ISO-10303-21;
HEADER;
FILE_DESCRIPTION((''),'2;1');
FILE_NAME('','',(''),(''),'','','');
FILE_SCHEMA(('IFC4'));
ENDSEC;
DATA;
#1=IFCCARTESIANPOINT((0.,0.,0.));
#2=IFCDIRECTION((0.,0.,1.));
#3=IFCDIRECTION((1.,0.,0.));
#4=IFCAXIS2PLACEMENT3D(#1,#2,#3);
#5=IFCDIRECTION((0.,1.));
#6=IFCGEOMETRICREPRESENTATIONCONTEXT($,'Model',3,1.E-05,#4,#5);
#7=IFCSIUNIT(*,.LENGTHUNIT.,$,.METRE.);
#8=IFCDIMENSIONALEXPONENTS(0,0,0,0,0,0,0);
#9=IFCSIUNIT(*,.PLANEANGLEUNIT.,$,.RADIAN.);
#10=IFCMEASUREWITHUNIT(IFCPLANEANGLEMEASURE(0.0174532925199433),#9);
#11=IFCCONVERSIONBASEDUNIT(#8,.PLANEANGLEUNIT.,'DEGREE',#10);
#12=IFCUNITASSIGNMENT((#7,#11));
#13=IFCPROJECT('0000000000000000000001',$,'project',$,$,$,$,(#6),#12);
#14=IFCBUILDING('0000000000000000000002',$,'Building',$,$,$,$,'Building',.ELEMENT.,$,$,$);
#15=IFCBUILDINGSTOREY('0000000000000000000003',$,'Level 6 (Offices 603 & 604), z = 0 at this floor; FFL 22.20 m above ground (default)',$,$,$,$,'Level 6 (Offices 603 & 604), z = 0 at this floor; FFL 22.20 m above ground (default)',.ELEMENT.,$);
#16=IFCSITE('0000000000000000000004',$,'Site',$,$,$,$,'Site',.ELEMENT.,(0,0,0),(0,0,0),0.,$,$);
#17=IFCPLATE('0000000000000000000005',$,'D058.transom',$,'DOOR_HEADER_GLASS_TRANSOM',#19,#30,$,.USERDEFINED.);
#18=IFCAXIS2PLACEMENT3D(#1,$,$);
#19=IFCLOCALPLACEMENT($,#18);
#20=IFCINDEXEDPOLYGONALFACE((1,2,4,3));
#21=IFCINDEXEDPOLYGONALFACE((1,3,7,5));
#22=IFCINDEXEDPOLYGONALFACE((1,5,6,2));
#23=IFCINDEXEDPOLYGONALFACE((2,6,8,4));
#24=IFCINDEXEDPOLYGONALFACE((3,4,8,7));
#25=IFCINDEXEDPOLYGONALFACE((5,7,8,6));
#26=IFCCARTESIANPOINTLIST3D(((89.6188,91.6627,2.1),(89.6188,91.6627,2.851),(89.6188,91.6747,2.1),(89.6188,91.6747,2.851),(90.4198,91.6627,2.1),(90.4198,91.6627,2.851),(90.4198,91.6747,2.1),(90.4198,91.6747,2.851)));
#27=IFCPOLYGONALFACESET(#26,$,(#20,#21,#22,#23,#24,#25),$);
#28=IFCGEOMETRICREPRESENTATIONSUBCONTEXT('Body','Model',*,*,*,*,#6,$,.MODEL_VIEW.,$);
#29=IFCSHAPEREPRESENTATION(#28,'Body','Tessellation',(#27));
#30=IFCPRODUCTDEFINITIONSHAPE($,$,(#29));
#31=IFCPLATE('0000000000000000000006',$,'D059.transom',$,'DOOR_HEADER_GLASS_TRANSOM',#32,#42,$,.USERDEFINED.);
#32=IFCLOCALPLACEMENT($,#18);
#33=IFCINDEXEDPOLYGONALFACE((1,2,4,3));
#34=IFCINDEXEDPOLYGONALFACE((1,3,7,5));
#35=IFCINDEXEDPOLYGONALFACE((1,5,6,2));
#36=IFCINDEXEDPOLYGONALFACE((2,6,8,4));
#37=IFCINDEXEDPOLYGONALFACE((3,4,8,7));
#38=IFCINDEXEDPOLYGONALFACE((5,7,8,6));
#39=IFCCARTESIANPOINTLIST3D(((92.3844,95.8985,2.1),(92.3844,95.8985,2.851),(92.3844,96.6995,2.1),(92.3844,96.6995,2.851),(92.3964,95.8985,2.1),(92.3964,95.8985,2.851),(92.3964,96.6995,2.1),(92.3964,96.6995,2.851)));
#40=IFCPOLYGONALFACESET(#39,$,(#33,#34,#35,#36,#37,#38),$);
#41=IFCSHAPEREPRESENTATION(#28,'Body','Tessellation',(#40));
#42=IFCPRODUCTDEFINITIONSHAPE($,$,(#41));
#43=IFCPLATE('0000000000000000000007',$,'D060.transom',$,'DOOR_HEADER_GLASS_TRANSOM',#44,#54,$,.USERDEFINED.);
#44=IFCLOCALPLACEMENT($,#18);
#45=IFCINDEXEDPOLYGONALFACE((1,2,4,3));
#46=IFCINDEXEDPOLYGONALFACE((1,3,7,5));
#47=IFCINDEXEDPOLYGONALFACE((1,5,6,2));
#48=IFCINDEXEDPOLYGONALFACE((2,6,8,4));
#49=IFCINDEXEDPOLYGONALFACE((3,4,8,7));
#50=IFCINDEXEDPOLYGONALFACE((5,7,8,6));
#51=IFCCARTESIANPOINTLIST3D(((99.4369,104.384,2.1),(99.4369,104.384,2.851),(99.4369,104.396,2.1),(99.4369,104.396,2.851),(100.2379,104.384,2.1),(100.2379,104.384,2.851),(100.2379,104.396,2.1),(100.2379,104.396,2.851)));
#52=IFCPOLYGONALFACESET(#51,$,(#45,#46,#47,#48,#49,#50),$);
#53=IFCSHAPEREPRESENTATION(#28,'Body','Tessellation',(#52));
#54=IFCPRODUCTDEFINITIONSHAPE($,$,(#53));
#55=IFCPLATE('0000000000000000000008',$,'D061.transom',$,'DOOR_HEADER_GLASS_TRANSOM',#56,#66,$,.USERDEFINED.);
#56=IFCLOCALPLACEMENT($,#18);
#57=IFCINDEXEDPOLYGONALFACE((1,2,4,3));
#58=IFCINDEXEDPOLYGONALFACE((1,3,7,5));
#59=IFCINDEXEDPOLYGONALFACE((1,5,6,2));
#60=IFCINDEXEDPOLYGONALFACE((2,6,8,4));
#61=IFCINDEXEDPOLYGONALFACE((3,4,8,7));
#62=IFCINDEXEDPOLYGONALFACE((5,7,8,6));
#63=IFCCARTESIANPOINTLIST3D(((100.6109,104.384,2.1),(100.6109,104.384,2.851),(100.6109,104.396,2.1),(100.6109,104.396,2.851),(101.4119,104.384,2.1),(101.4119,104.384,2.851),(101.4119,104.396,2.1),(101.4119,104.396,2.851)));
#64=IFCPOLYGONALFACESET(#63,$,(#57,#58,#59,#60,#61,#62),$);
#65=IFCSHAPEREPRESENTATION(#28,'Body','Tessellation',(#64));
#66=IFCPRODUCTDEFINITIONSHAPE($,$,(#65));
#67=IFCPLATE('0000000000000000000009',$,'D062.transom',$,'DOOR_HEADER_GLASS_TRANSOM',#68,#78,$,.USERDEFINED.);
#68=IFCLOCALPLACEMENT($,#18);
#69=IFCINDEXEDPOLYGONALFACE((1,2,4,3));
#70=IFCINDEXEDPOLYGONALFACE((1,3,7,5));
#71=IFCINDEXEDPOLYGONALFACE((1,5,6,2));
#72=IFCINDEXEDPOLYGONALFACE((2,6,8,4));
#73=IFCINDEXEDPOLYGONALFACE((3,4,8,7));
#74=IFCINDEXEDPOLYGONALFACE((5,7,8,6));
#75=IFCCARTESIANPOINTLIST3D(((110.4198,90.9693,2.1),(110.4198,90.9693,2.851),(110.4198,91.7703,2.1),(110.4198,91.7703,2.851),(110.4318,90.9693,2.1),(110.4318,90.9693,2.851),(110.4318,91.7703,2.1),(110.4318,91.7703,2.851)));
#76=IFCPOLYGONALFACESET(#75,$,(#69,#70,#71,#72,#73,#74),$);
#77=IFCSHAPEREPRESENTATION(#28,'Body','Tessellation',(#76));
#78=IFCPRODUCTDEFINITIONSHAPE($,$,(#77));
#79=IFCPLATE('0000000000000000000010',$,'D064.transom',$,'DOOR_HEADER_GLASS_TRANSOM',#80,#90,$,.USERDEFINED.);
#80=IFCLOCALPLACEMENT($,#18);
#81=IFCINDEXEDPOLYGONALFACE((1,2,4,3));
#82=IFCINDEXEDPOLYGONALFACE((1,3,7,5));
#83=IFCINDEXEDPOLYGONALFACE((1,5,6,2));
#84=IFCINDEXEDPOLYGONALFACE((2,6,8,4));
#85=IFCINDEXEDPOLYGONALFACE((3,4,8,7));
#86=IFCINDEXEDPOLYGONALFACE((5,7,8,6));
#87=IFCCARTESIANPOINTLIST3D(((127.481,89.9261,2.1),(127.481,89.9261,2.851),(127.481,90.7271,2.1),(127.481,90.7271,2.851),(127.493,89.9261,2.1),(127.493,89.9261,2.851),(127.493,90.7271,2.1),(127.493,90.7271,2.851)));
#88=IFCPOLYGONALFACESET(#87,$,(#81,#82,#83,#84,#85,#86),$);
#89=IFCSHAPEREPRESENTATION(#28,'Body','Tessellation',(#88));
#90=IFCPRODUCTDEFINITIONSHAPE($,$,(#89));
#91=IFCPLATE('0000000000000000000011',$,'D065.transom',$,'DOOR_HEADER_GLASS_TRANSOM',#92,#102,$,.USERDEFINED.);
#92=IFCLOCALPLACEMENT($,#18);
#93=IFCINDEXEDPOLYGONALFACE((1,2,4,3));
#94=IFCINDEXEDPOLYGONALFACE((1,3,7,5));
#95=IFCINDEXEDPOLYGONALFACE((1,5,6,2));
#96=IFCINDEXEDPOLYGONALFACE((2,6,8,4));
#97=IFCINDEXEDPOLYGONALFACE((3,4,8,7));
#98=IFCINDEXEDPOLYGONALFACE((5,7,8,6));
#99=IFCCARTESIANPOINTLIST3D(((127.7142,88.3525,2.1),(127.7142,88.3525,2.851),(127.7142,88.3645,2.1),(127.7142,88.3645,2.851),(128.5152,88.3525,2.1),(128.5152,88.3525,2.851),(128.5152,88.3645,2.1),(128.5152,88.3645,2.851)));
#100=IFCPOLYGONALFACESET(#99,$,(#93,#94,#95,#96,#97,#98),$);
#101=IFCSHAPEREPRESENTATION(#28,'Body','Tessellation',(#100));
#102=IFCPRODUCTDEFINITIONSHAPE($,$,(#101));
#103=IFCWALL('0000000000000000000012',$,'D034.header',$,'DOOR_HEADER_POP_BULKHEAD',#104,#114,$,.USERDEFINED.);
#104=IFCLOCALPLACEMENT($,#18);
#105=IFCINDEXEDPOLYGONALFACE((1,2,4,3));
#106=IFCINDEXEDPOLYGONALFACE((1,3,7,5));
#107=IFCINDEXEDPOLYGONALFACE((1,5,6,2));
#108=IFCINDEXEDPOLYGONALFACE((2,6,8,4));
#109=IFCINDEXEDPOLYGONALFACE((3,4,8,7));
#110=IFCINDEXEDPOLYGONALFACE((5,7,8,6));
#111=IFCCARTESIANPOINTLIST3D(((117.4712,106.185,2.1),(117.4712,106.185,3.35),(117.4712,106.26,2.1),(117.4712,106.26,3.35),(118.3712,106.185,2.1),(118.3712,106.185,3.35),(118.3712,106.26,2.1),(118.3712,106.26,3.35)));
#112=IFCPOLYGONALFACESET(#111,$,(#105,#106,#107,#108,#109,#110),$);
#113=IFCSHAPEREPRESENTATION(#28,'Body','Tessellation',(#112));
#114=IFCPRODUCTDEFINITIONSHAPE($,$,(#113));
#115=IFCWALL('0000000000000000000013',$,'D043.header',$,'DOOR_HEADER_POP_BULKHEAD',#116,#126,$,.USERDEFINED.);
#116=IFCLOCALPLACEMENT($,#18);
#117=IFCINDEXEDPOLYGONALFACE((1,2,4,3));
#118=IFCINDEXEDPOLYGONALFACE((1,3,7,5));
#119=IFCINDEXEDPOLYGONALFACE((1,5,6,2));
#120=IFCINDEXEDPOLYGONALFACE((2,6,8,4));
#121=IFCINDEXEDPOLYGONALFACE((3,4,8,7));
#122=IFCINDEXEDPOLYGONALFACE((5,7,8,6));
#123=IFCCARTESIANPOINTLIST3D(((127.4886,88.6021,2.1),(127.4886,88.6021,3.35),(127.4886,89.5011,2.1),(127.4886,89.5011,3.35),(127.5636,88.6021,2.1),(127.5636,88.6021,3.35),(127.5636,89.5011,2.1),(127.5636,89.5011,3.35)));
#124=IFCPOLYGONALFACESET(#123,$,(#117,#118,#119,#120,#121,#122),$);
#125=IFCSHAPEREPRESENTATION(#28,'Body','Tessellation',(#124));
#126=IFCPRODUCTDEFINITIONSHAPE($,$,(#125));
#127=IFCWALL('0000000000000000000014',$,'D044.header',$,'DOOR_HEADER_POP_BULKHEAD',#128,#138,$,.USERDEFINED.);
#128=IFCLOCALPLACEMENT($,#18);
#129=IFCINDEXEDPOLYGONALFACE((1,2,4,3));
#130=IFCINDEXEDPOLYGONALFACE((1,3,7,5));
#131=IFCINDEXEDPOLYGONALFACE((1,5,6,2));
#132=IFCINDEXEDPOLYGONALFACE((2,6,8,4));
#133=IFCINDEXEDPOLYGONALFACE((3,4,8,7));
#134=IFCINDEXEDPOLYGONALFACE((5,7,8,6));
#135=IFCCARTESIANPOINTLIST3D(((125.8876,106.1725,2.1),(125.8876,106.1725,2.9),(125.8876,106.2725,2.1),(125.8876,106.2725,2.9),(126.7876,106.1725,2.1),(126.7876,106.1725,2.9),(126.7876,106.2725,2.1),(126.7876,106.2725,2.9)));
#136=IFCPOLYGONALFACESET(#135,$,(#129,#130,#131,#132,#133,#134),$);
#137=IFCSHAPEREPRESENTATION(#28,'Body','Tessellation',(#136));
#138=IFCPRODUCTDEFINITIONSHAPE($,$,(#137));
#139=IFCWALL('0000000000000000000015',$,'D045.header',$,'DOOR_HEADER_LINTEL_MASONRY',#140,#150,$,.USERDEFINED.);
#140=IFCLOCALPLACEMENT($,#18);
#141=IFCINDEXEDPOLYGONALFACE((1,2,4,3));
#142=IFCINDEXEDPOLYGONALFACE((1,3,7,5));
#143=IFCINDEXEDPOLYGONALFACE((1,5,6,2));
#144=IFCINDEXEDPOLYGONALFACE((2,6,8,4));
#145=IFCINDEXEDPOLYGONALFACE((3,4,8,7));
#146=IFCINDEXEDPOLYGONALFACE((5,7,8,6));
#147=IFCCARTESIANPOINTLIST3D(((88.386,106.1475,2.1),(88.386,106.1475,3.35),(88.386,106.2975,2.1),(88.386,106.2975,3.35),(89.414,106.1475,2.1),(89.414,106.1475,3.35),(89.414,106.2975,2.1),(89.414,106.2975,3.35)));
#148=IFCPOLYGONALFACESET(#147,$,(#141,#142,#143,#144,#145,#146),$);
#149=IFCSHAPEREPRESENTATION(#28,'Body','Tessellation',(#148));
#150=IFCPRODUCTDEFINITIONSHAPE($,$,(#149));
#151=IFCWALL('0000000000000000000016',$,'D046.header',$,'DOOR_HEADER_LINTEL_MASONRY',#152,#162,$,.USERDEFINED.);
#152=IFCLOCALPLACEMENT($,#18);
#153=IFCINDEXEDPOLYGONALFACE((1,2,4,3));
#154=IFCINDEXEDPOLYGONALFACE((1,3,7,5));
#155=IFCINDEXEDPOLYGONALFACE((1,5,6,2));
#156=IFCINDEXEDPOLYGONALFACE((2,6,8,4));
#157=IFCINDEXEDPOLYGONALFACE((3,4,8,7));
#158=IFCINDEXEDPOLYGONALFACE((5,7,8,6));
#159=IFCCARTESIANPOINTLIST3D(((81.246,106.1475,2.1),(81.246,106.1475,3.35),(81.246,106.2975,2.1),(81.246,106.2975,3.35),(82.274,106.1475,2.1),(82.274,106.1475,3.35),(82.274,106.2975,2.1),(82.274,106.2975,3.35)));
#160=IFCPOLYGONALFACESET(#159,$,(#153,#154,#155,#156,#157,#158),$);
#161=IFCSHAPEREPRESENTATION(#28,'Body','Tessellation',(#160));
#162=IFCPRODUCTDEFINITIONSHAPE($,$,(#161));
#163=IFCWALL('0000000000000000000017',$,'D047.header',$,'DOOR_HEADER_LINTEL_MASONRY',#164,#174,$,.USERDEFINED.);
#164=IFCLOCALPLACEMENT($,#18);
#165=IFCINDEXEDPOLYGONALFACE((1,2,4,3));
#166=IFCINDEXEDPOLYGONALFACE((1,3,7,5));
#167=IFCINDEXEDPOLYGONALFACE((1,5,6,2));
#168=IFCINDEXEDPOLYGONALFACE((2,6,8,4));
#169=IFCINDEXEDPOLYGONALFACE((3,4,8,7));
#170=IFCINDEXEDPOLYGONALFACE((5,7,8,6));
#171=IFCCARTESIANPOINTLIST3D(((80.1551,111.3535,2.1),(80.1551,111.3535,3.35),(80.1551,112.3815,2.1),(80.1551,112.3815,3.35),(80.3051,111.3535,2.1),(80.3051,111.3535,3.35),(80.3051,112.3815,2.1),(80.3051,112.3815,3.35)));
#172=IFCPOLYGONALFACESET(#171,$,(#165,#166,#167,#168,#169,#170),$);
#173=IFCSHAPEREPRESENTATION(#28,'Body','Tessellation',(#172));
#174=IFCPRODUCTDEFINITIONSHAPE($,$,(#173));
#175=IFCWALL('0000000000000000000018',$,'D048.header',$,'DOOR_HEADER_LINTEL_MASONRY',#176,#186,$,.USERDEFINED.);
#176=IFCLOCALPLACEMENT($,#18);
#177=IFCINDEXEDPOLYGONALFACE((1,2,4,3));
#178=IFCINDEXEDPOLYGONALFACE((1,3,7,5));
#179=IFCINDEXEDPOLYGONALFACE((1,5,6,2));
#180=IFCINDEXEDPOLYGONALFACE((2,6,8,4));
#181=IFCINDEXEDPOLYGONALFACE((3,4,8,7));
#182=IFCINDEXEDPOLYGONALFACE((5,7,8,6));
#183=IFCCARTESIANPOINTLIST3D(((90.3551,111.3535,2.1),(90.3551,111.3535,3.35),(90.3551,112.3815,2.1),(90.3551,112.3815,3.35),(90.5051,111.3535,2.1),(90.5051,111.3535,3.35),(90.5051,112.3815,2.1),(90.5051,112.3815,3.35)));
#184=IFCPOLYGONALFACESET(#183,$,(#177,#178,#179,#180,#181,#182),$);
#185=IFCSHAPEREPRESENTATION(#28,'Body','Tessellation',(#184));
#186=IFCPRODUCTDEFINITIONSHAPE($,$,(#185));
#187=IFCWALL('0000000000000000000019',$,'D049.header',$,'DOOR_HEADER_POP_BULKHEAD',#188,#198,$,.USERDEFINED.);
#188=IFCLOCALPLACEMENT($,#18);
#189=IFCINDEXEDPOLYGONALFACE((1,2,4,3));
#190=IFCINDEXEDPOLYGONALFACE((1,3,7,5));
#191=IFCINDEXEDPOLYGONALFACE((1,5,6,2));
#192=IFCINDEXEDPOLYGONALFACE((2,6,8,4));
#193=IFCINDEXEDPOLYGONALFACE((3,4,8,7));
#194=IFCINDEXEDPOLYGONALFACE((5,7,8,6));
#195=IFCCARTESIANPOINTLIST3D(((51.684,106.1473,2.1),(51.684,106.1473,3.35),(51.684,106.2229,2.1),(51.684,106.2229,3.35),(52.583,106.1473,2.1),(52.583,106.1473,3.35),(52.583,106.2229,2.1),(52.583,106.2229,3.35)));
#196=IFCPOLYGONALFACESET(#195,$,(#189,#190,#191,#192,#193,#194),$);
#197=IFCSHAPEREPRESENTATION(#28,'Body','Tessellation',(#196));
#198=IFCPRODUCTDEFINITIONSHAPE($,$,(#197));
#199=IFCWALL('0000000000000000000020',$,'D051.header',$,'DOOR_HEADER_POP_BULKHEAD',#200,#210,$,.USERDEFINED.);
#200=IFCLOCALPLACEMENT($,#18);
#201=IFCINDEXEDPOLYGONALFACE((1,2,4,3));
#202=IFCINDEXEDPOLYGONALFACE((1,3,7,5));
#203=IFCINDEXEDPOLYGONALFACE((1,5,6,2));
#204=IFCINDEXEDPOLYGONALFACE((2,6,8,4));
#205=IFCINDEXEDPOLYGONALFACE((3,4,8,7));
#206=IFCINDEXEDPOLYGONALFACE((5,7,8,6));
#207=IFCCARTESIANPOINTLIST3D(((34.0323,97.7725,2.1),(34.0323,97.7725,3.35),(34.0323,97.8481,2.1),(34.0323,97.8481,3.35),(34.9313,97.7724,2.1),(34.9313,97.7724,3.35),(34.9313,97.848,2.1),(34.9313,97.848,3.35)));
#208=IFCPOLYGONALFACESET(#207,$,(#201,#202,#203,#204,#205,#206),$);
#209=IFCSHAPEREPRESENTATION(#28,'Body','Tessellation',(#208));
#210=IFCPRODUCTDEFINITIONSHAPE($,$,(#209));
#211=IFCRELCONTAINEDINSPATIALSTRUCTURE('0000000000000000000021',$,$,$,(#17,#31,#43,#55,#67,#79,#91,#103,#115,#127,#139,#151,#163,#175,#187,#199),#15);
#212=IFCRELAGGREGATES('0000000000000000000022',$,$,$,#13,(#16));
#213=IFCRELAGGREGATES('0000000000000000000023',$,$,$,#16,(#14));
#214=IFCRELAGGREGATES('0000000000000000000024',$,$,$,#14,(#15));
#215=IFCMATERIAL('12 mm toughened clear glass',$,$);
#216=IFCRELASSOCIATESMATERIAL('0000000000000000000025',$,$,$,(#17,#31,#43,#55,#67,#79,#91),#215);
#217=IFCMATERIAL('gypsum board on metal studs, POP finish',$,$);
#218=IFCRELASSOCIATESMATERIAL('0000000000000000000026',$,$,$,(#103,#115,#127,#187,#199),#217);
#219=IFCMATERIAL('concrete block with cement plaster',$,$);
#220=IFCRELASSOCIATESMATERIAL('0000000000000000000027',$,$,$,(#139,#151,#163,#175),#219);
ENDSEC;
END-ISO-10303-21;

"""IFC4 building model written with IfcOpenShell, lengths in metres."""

from ifc_helpers import new_model, entity, si_unit, converted_unit, direction, frame, frame_2d, origin_with_axes, origin_2d_with_axis, place, context, subcontext, project, spatial, rectangle, extrude, material, element, save


model = new_model("IFC4")

# Units and contexts
model_context = context("Model", 3, precision=1e-05, world=origin_with_axes(), true_north=direction((0.0, 1.0)))
body_context = subcontext(model_context, "Body", "Model", "MODEL_VIEW")
ifc_project = project(units=[si_unit("LENGTHUNIT", "METRE"), converted_unit("PLANEANGLEUNIT", "DEGREE", entity("IfcPlaneAngleMeasure", 0.0174532925199433), si_unit("PLANEANGLEUNIT", "RADIAN"), dimensions=[0, 0, 0, 0, 0, 0, 0])], contexts=[model_context])

# Site, building, storey
site = spatial("IfcSite", under=ifc_project, Name="Site", LongName="Site", CompositionType="ELEMENT", RefLatitude=(0, 0, 0), RefLongitude=(0, 0, 0), RefElevation=0.0)
building = spatial("IfcBuilding", under=site, Name="Building", LongName="Building", CompositionType="ELEMENT")
storey = spatial("IfcBuildingStorey", under=building, Name="Level 6 (Offices 603 & 604), z = 0 at this floor; FFL 22.20 m above ground (default)", LongName="Level 6 (Offices 603 & 604), z = 0 at this floor; FFL 22.20 m above ground (default)", CompositionType="ELEMENT")

# Plates
ifc_material_1 = material(Name="12 mm toughened clear glass")
placement = place(None, origin_with_axes())
element("IfcPlate", 1, at=placement, inside=storey, material=ifc_material_1, Name="D058.transom", ObjectType="DOOR_HEADER_GLASS_TRANSOM", PredefinedType="USERDEFINED", context=body_context, shape_type="SweptSolid", body=[
    extrude(rectangle(XDim=0.801, YDim=0.012, at=frame_2d((0.0, 0.0), x_axis=(1.0, 0.0))), frame((90.0192, 91.6687, 2.1), z_axis=(0.0, 0.0, 1.0), x_axis=(1.0, 0.0, 0.0)), (0.0, 0.0, 1.0), 0.751),
])
element("IfcPlate", 2, at=placement, inside=storey, material=ifc_material_1, Name="D059.transom", ObjectType="DOOR_HEADER_GLASS_TRANSOM", PredefinedType="USERDEFINED", context=body_context, shape_type="SweptSolid", body=[
    extrude(rectangle(XDim=0.801, YDim=0.012, at=frame_2d((0.0, 0.0), x_axis=(0.0, 1.0))), frame((92.3904, 96.299, 2.1), z_axis=(0.0, 0.0, 1.0), x_axis=(1.0, 0.0, 0.0)), (0.0, 0.0, 1.0), 0.751),
])
element("IfcPlate", 3, at=placement, inside=storey, material=ifc_material_1, Name="D060.transom", ObjectType="DOOR_HEADER_GLASS_TRANSOM", PredefinedType="USERDEFINED", context=body_context, shape_type="SweptSolid", body=[
    extrude(rectangle(XDim=0.801, YDim=0.012, at=origin_2d_with_axis()), frame((99.8374, 104.39, 2.1), z_axis=(0.0, 0.0, 1.0), x_axis=(1.0, 0.0, 0.0)), (0.0, 0.0, 1.0), 0.751),
])
element("IfcPlate", 4, at=placement, inside=storey, material=ifc_material_1, Name="D061.transom", ObjectType="DOOR_HEADER_GLASS_TRANSOM", PredefinedType="USERDEFINED", context=body_context, shape_type="SweptSolid", body=[
    extrude(rectangle(XDim=0.801, YDim=0.012, at=frame_2d((0.0, 0.0), x_axis=(1.0, 0.0))), frame((101.0114, 104.39, 2.1), z_axis=(0.0, 0.0, 1.0), x_axis=(1.0, 0.0, 0.0)), (0.0, 0.0, 1.0), 0.751),
])
element("IfcPlate", 5, at=placement, inside=storey, material=ifc_material_1, Name="D062.transom", ObjectType="DOOR_HEADER_GLASS_TRANSOM", PredefinedType="USERDEFINED", context=body_context, shape_type="SweptSolid", body=[
    extrude(rectangle(XDim=0.801, YDim=0.012, at=frame_2d((0.0, 0.0), x_axis=(0.0, 1.0))), frame((110.4258, 91.3698, 2.1), z_axis=(0.0, 0.0, 1.0), x_axis=(1.0, 0.0, 0.0)), (0.0, 0.0, 1.0), 0.751),
])
element("IfcPlate", 6, at=placement, inside=storey, material=ifc_material_1, Name="D064.transom", ObjectType="DOOR_HEADER_GLASS_TRANSOM", PredefinedType="USERDEFINED", context=body_context, shape_type="SweptSolid", body=[
    extrude(rectangle(XDim=0.801, YDim=0.012, at=frame_2d((0.0, 0.0), x_axis=(0.0, 1.0))), frame((127.487, 90.3266, 2.1), z_axis=(0.0, 0.0, 1.0), x_axis=(1.0, 0.0, 0.0)), (0.0, 0.0, 1.0), 0.751),
])
element("IfcPlate", 7, at=placement, inside=storey, material=ifc_material_1, Name="D065.transom", ObjectType="DOOR_HEADER_GLASS_TRANSOM", PredefinedType="USERDEFINED", context=body_context, shape_type="SweptSolid", body=[
    extrude(rectangle(XDim=0.801, YDim=0.012, at=origin_2d_with_axis()), frame((128.1147, 88.3585, 2.1), z_axis=(0.0, 0.0, 1.0), x_axis=(1.0, 0.0, 0.0)), (0.0, 0.0, 1.0), 0.751),
])

# Walls
ifc_material_2 = material(Name="gypsum board on metal studs, POP finish")
element("IfcWall", 8, at=placement, inside=storey, material=ifc_material_2, Name="D034.header", ObjectType="DOOR_HEADER_POP_BULKHEAD", PredefinedType="USERDEFINED", context=body_context, shape_type="SweptSolid", body=[
    extrude(rectangle(XDim=0.9, YDim=0.075, at=frame_2d((0.0, 0.0), x_axis=(1.0, 0.0))), frame((117.9212, 106.2225, 2.1), z_axis=(0.0, 0.0, 1.0), x_axis=(1.0, 0.0, 0.0)), (0.0, 0.0, 1.0), 1.25),
])
element("IfcWall", 9, at=placement, inside=storey, material=ifc_material_2, Name="D043.header", ObjectType="DOOR_HEADER_POP_BULKHEAD", PredefinedType="USERDEFINED", context=body_context, shape_type="SweptSolid", body=[
    extrude(rectangle(XDim=0.899, YDim=0.075, at=frame_2d((0.0, 0.0), x_axis=(0.0, 1.0))), frame((127.5261, 89.0516, 2.1), z_axis=(0.0, 0.0, 1.0), x_axis=(1.0, 0.0, 0.0)), (0.0, 0.0, 1.0), 1.25),
])
element("IfcWall", 10, at=placement, inside=storey, material=ifc_material_2, Name="D044.header", ObjectType="DOOR_HEADER_POP_BULKHEAD", PredefinedType="USERDEFINED", context=body_context, shape_type="SweptSolid", body=[
    extrude(rectangle(XDim=0.9, YDim=0.1, at=frame_2d((0.0, 0.0), x_axis=(1.0, 0.0))), frame((126.3376, 106.2225, 2.1), z_axis=(0.0, 0.0, 1.0), x_axis=(1.0, 0.0, 0.0)), (0.0, 0.0, 1.0), 0.8),
])
ifc_material_3 = material(Name="concrete block with cement plaster")
element("IfcWall", 11, at=placement, inside=storey, material=ifc_material_3, Name="D045.header", ObjectType="DOOR_HEADER_LINTEL_MASONRY", PredefinedType="USERDEFINED", context=body_context, shape_type="SweptSolid", body=[
    extrude(rectangle(XDim=1.028, YDim=0.15, at=frame_2d((0.0, 0.0), x_axis=(1.0, 0.0))), frame((88.9, 106.2225, 2.1), z_axis=(0.0, 0.0, 1.0), x_axis=(1.0, 0.0, 0.0)), (0.0, 0.0, 1.0), 1.25),
])
element("IfcWall", 12, at=placement, inside=storey, material=ifc_material_3, Name="D046.header", ObjectType="DOOR_HEADER_LINTEL_MASONRY", PredefinedType="USERDEFINED", context=body_context, shape_type="SweptSolid", body=[
    extrude(rectangle(XDim=1.028, YDim=0.15, at=frame_2d((0.0, 0.0), x_axis=(1.0, 0.0))), frame((81.76, 106.2225, 2.1), z_axis=(0.0, 0.0, 1.0), x_axis=(1.0, 0.0, 0.0)), (0.0, 0.0, 1.0), 1.25),
])
element("IfcWall", 13, at=placement, inside=storey, material=ifc_material_3, Name="D047.header", ObjectType="DOOR_HEADER_LINTEL_MASONRY", PredefinedType="USERDEFINED", context=body_context, shape_type="SweptSolid", body=[
    extrude(rectangle(XDim=1.028, YDim=0.15, at=frame_2d((0.0, 0.0), x_axis=(0.0, 1.0))), frame((80.2301, 111.8675, 2.1), z_axis=(0.0, 0.0, 1.0), x_axis=(1.0, 0.0, 0.0)), (0.0, 0.0, 1.0), 1.25),
])
element("IfcWall", 14, at=placement, inside=storey, material=ifc_material_3, Name="D048.header", ObjectType="DOOR_HEADER_LINTEL_MASONRY", PredefinedType="USERDEFINED", context=body_context, shape_type="SweptSolid", body=[
    extrude(rectangle(XDim=1.028, YDim=0.15, at=frame_2d((0.0, 0.0), x_axis=(0.0, 1.0))), frame((90.4301, 111.8675, 2.1), z_axis=(0.0, 0.0, 1.0), x_axis=(1.0, 0.0, 0.0)), (0.0, 0.0, 1.0), 1.25),
])
element("IfcWall", 15, at=placement, inside=storey, material=ifc_material_2, Name="D049.header", ObjectType="DOOR_HEADER_POP_BULKHEAD", PredefinedType="USERDEFINED", context=body_context, shape_type="SweptSolid", body=[
    extrude(rectangle(XDim=0.899, YDim=0.0756, at=frame_2d((0.0, 0.0), x_axis=(1.0, 0.0))), frame((52.1335, 106.1851, 2.1), z_axis=(0.0, 0.0, 1.0), x_axis=(1.0, 0.0, 0.0)), (0.0, 0.0, 1.0), 1.25),
])
element("IfcWall", 16, at=placement, inside=storey, material=ifc_material_2, Name="D051.header", ObjectType="DOOR_HEADER_POP_BULKHEAD", PredefinedType="USERDEFINED", context=body_context, shape_type="SweptSolid", body=[
    extrude(rectangle(XDim=0.899, YDim=0.0756, at=frame_2d((0.0, 0.0), x_axis=(1.0, -0.00012))), frame((34.4818, 97.8102, 2.1), z_axis=(0.0, 0.0, 1.0), x_axis=(1.0, 0.0, 0.0)), (0.0, 0.0, 1.0), 1.25),
])

save(model, "model.ifc")
